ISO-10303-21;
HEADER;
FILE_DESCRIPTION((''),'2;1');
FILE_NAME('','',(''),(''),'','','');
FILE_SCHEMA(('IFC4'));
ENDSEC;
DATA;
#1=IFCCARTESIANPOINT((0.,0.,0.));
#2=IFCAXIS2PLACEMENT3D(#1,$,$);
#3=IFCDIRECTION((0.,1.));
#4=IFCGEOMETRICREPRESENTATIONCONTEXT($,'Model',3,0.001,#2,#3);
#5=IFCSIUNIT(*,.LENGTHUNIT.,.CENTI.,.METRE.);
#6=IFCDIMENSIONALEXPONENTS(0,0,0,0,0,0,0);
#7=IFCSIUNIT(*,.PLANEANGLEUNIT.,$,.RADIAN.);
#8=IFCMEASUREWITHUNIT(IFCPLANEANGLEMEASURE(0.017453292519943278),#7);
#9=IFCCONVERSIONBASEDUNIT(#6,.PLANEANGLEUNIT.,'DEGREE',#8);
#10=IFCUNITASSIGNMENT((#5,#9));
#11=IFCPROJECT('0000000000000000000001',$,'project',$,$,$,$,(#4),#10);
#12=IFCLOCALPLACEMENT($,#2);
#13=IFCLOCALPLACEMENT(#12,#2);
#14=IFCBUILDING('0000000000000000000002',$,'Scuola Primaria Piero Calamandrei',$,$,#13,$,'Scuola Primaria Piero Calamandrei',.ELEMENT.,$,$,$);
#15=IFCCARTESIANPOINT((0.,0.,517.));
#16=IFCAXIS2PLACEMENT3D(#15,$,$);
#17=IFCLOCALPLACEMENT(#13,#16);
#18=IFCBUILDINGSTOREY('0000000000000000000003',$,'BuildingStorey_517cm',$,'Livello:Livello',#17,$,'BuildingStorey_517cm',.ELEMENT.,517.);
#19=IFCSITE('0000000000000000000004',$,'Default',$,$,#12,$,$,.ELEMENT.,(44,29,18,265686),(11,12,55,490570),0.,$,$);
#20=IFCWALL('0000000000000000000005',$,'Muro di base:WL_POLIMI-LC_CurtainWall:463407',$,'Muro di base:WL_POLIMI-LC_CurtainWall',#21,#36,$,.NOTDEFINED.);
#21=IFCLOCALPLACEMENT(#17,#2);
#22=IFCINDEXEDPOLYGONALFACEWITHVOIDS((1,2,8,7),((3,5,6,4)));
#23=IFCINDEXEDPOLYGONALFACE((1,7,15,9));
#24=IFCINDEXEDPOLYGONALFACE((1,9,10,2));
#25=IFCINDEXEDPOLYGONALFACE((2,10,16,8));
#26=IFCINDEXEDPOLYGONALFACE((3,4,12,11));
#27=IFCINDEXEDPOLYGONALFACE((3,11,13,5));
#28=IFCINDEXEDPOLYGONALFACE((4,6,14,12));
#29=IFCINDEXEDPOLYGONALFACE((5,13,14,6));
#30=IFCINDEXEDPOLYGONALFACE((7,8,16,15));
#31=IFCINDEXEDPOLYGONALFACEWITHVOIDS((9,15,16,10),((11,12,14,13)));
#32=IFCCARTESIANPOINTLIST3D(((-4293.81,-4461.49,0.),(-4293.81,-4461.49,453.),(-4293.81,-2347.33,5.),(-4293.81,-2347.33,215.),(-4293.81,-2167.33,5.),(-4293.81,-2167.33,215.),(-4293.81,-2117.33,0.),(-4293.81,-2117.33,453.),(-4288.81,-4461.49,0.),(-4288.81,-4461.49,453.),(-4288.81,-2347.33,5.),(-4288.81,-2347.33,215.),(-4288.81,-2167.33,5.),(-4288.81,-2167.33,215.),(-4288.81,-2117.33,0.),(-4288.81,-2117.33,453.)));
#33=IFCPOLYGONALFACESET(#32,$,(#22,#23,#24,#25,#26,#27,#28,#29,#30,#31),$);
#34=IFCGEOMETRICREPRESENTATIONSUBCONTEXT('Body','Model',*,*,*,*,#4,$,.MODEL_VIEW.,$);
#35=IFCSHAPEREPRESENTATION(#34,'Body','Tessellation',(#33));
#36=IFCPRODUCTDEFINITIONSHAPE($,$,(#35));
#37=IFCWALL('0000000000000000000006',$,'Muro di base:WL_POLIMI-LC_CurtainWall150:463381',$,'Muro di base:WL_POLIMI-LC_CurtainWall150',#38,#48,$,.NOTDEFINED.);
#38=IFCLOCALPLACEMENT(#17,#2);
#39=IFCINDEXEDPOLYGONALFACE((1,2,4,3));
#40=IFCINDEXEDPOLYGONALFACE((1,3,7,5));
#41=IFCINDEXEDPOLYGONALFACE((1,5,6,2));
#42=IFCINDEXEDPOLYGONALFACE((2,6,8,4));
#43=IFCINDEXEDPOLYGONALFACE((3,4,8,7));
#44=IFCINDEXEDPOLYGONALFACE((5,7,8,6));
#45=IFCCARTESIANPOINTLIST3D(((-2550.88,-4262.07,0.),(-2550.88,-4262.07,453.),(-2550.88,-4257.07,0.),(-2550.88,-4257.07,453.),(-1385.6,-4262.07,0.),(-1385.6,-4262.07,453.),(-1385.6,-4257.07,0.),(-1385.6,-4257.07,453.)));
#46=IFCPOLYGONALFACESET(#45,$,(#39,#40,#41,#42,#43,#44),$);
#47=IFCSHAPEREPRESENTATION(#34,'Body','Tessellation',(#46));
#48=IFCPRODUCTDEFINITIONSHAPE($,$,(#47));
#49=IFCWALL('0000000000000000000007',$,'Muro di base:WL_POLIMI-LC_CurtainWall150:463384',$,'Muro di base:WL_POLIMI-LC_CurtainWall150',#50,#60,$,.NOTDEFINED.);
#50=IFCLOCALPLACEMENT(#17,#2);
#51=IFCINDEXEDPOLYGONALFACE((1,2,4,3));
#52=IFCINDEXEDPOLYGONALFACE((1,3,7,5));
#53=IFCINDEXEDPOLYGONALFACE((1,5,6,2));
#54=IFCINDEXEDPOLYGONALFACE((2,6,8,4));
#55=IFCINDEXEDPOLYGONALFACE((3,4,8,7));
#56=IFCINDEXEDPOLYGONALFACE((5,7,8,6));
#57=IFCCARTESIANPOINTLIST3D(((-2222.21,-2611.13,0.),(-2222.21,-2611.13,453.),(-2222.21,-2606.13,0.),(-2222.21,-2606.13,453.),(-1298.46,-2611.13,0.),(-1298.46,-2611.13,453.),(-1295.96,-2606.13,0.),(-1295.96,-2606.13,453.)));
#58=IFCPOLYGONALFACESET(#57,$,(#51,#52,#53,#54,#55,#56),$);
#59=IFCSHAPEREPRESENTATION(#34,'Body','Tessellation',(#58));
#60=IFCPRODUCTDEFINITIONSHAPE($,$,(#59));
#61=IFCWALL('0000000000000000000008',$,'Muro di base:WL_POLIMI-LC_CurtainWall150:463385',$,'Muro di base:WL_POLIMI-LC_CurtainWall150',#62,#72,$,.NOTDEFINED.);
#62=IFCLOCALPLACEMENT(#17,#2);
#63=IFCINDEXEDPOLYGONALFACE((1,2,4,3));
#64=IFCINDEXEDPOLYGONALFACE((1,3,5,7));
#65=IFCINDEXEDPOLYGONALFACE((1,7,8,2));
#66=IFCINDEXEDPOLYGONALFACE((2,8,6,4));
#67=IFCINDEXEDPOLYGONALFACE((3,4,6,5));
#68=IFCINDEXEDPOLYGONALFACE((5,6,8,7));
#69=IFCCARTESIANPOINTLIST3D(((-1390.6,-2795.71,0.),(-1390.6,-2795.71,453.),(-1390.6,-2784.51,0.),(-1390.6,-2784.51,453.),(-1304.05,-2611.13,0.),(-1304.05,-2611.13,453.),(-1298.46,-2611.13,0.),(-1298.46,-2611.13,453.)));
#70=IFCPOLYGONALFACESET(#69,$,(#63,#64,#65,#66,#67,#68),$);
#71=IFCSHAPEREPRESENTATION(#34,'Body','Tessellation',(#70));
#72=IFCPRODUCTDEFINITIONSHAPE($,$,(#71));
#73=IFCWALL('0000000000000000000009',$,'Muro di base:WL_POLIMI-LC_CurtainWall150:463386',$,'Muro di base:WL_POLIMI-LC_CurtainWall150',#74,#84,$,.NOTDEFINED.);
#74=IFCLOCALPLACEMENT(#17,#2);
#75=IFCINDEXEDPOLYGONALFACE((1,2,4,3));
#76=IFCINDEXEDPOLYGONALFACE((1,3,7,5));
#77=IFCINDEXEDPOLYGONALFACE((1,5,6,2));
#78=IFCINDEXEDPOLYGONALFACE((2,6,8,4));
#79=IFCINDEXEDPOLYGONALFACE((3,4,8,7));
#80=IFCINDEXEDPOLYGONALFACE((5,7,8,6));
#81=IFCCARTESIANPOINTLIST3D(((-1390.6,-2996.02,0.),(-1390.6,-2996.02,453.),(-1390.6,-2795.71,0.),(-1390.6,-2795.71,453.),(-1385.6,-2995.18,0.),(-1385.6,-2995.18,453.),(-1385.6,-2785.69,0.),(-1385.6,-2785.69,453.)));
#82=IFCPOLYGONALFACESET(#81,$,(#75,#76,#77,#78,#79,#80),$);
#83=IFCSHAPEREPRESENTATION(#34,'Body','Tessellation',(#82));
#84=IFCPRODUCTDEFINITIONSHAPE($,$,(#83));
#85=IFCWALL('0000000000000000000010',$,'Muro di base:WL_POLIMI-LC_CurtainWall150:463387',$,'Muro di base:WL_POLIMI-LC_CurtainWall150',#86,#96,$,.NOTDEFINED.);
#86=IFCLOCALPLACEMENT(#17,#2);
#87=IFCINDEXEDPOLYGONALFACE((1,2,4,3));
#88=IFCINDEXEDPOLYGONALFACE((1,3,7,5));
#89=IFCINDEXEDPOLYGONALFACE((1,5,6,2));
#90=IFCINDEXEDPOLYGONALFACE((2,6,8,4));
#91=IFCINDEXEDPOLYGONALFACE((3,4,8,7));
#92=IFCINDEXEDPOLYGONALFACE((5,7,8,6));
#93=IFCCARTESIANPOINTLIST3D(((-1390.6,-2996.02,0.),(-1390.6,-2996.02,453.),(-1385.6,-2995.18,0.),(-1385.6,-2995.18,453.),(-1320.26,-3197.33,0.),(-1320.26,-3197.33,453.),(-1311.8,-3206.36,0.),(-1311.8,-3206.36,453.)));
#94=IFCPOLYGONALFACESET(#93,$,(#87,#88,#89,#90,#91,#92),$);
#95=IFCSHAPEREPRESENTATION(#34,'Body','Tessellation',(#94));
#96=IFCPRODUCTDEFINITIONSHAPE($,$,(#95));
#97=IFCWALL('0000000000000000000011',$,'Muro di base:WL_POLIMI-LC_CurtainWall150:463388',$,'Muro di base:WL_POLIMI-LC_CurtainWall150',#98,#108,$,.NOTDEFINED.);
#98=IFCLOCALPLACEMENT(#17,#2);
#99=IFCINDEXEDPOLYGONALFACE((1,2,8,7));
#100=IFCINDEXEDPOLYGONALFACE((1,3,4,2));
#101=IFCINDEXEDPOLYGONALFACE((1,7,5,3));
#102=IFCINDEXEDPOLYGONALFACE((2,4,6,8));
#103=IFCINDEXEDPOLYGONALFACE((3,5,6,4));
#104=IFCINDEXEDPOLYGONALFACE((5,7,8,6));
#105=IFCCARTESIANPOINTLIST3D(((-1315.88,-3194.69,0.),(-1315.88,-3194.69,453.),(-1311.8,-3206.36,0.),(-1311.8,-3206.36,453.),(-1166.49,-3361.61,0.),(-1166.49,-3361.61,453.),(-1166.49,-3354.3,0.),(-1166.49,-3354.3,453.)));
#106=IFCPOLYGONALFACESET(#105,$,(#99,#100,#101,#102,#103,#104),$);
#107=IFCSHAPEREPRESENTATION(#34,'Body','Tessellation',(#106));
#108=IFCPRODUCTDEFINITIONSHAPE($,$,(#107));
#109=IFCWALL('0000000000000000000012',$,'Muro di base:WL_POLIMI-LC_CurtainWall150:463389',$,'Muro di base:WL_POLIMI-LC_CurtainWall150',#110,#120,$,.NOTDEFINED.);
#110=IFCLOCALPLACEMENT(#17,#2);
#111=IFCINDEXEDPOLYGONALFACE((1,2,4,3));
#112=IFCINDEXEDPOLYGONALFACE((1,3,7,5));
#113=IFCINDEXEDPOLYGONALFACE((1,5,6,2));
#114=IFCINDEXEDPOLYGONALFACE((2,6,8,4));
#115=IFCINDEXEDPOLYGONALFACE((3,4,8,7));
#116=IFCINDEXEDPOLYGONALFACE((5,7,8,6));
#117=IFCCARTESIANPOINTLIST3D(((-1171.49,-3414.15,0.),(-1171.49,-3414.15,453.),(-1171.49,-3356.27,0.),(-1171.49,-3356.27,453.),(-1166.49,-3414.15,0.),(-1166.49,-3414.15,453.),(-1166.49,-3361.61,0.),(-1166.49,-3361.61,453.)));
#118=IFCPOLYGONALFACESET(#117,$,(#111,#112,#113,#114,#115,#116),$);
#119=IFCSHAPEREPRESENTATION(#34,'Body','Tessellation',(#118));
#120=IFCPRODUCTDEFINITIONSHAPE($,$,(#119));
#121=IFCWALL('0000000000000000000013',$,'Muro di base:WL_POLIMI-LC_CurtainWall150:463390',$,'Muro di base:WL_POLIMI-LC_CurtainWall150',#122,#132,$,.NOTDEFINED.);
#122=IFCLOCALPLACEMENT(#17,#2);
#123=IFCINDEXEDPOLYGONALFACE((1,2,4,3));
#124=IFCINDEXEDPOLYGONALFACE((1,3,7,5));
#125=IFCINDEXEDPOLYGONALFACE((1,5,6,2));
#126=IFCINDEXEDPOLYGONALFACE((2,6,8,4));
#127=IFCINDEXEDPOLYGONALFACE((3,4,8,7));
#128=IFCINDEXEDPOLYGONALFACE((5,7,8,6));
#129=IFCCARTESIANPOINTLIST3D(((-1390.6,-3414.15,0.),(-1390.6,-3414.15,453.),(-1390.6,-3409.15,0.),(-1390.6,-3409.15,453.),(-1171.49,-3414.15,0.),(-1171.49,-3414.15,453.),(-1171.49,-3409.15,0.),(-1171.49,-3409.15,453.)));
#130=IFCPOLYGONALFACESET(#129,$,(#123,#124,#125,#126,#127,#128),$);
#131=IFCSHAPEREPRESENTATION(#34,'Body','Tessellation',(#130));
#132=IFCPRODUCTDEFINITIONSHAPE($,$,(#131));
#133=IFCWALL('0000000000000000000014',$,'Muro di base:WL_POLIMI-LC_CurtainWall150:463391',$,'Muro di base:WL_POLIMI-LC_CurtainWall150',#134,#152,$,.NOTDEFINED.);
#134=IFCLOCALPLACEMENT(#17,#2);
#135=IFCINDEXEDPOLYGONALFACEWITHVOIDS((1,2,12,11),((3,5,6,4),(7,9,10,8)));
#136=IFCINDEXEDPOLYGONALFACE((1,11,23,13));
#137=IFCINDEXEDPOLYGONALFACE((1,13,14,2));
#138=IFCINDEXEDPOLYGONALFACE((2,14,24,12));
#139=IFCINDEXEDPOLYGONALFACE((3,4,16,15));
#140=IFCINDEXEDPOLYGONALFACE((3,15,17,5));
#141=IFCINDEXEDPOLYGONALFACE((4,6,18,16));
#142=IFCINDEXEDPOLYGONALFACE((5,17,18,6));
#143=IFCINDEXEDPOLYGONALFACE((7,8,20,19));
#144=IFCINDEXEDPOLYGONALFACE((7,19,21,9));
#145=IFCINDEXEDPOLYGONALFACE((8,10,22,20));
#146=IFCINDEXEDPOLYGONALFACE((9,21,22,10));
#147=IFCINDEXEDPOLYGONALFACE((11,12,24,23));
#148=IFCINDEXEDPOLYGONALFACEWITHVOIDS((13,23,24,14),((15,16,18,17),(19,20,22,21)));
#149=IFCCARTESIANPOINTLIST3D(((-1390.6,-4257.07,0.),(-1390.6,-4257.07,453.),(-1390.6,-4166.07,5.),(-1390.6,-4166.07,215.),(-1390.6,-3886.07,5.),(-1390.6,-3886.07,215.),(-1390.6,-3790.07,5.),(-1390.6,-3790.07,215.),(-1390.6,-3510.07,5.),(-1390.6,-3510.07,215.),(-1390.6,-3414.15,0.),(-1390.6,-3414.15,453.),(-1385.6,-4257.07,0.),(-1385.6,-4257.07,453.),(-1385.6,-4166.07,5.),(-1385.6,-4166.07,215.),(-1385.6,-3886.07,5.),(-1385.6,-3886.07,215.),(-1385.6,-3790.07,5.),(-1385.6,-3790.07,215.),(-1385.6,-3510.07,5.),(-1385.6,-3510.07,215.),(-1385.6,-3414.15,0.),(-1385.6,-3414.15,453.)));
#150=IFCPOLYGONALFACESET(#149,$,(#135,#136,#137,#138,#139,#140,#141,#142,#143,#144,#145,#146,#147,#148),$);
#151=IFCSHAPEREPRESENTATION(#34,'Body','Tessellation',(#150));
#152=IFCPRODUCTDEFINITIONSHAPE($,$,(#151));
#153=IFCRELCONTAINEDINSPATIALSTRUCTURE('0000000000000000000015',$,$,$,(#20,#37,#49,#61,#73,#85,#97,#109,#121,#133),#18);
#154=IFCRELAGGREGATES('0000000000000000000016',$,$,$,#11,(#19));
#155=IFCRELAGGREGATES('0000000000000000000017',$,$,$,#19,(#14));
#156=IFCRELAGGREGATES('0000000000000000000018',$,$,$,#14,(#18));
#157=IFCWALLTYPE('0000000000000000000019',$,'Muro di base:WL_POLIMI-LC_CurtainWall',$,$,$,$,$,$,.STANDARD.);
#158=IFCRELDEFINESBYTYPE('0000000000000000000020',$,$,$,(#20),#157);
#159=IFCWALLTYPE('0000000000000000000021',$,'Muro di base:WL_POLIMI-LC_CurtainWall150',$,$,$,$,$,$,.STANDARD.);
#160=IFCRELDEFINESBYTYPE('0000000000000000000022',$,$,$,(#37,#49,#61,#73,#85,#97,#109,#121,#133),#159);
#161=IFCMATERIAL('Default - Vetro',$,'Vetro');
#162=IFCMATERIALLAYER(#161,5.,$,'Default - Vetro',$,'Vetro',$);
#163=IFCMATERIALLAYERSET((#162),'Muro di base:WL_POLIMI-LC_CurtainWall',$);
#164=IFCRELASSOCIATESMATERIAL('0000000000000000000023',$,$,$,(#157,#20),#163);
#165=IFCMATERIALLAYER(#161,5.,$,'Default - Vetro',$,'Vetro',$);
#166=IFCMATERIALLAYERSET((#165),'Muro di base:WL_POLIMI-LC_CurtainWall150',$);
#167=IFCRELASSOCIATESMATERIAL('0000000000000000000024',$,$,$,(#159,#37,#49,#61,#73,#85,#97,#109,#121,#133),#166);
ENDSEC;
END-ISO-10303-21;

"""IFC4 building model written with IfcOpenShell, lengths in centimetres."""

from ifc_helpers import new_model, entity, si_unit, converted_unit, direction, frame, frame_2d, origin, place, context, subcontext, project, spatial, polyline, rectangle, outline, extrude, clip, bounded_halfspace, material, layer, layer_set, layer_usage, type_object, element, save


model = new_model("IFC4")

# Units and contexts
model_context = context("Model", 3, precision=0.001, world=origin(), true_north=direction((0.0, 1.0)))
body_context = subcontext(model_context, "Body", "Model", "MODEL_VIEW")
ifc_project = project(units=[si_unit("LENGTHUNIT", "METRE", prefix="CENTI"), converted_unit("PLANEANGLEUNIT", "DEGREE", entity("IfcPlaneAngleMeasure", 0.017453292519943278), si_unit("PLANEANGLEUNIT", "RADIAN"), dimensions=[0, 0, 0, 0, 0, 0, 0])], contexts=[model_context])

# Site, building, storey
site_placement = place(None, origin())
site = spatial("IfcSite", under=ifc_project, at=site_placement, Name="Default", CompositionType="ELEMENT", RefLatitude=(44, 29, 18, 265686), RefLongitude=(11, 12, 55, 490570), RefElevation=0.0)
building_placement = place(site_placement, origin())
building = spatial("IfcBuilding", under=site, at=building_placement, Name="Scuola Primaria Piero Calamandrei", LongName="Scuola Primaria Piero Calamandrei", CompositionType="ELEMENT")
storey_placement = place(building_placement, frame((0.0, 0.0, 517.0)))
storey = spatial("IfcBuildingStorey", under=building, at=storey_placement, Name="BuildingStorey_517cm", ObjectType="Livello:Livello", LongName="BuildingStorey_517cm", CompositionType="ELEMENT", Elevation=517.0)

# Wall, opening
ifc_material_1 = material(Name="Default - Vetro", Category="Vetro")
ifc_layer_1 = layer(ifc_material_1, 5.0, Name="Default - Vetro", Category="Vetro")
ifc_layer_set_1 = layer_set([ifc_layer_1], Name="Muro di base:WL_POLIMI-LC_CurtainWall")
ifc_layer_usage_1 = layer_usage(ifc_layer_set_1, "AXIS2", "NEGATIVE", 2.5)
wall_type_1 = type_object("IfcWallType", Name="Muro di base:WL_POLIMI-LC_CurtainWall", PredefinedType="STANDARD", material=ifc_layer_set_1)
wall_1_placement = place(storey_placement, frame((-4291.31, -4461.49, 0.0), z_axis=(0.0, 0.0, 1.0), x_axis=(0.0, 1.0, 0.0)))
wall_1 = element("IfcWall", 1, at=wall_1_placement, inside=storey, type_object=wall_type_1, material=ifc_layer_usage_1, Name="Muro di base:WL_POLIMI-LC_CurtainWall:463407", ObjectType="Muro di base:WL_POLIMI-LC_CurtainWall", PredefinedType="NOTDEFINED", context=body_context, shape_type="Clipping", body=[
    clip(extrude(rectangle(XDim=2344.16, YDim=5.0, at=frame_2d((1172.08, 0.0), x_axis=(-1.0, 0.0))), origin(), (0.0, 0.0, 1.0), 453.0), bounded_halfspace(frame((0.0, -2.5, 453.0), z_axis=(0.0, 0.0, 1.0), x_axis=(0.0, -1.0, 0.0)), False, frame((0.0, -2.5, 453.0)), polyline([(0.0, 0.0), (2332.66, 0.0), (2344.16, 0.0), (2344.16, 5.0), (0.0, 5.0), (0.0, 0.0)]))),
])
opening_1_placement = place(wall_1_placement, frame((2114.16, -2.5, 5.0)))
element("IfcOpeningElement", 2, at=opening_1_placement, cuts=wall_1, PredefinedType="OPENING", context=body_context, shape_type="SweptSolid", body=[
    extrude(rectangle(XDim=210.0, YDim=180.0, at=frame_2d((105.0, 90.0), x_axis=(-1.0, 0.0))), frame((0.0, 0.0, 0.0), z_axis=(0.0, 1.0, 0.0), x_axis=(0.0, 0.0, 1.0)), (0.0, 0.0, 1.0), 5.0),
])

# Walls
ifc_layer_2 = layer(ifc_material_1, 5.0, Name="Default - Vetro", Category="Vetro")
ifc_layer_set_2 = layer_set([ifc_layer_2], Name="Muro di base:WL_POLIMI-LC_CurtainWall150")
ifc_layer_usage_2 = layer_usage(ifc_layer_set_2, "AXIS2", "NEGATIVE", 2.5)
wall_type_2 = type_object("IfcWallType", Name="Muro di base:WL_POLIMI-LC_CurtainWall150", PredefinedType="STANDARD", material=ifc_layer_set_2)
wall_2_placement = place(storey_placement, frame((-1385.6, -4259.57, 0.0), z_axis=(0.0, 0.0, 1.0), x_axis=(-1.0, 0.0, 0.0)))
element("IfcWall", 3, at=wall_2_placement, inside=storey, type_object=wall_type_2, material=ifc_layer_usage_2, Name="Muro di base:WL_POLIMI-LC_CurtainWall150:463381", ObjectType="Muro di base:WL_POLIMI-LC_CurtainWall150", PredefinedType="NOTDEFINED", context=body_context, shape_type="Clipping", body=[
    clip(extrude(rectangle(XDim=1165.28, YDim=5.0, at=frame_2d((582.64, 0.0), x_axis=(-1.0, 0.0))), origin(), (0.0, 0.0, 1.0), 453.0), bounded_halfspace(frame((0.0, -2.5, 453.0), z_axis=(0.0, 0.0, 1.0), x_axis=(-1.0, 0.0, 0.0)), False, frame((0.0, -2.5, 453.0)), polyline([(0.0, 0.0), (5.0, 0.0), (1165.28, 0.0), (1165.28, 5.0), (0.0, 5.0), (0.0, 0.0)]))),
])
ifc_layer_usage_3 = layer_usage(ifc_layer_set_2, "AXIS2", "NEGATIVE", 2.5)
wall_3_placement = place(storey_placement, frame((-2222.21, -2608.63, 0.0)))
element("IfcWall", 4, at=wall_3_placement, inside=storey, type_object=wall_type_2, material=ifc_layer_usage_3, Name="Muro di base:WL_POLIMI-LC_CurtainWall150:463384", ObjectType="Muro di base:WL_POLIMI-LC_CurtainWall150", PredefinedType="NOTDEFINED", context=body_context, shape_type="Clipping", body=[
    clip(extrude(outline(polyline([(923.75, -2.5), (926.24, 2.5), (0.0, 2.5), (0.0, -2.5), (918.16, -2.5), (923.75, -2.5)])), origin(), (0.0, 0.0, 1.0), 453.0), bounded_halfspace(frame((0.0, -2.5, 453.0)), False, frame((0.0, -2.5, 453.0)), polyline([(0.0, 0.0), (918.16, 0.0), (923.75, 0.0), (926.24, 5.0), (0.0, 5.0), (0.0, 0.0)]))),
])
ifc_layer_usage_4 = layer_usage(ifc_layer_set_2, "AXIS2", "NEGATIVE", 2.5)
wall_4_placement = place(storey_placement, frame((-1300.7, -2610.01, 0.0), z_axis=(0.0, 0.0, 1.0), x_axis=(-0.446642, -0.894713, 0.0)))
element("IfcWall", 5, at=wall_4_placement, inside=storey, type_object=wall_type_2, material=ifc_layer_usage_4, Name="Muro di base:WL_POLIMI-LC_CurtainWall150:463385", ObjectType="Muro di base:WL_POLIMI-LC_CurtainWall150", PredefinedType="NOTDEFINED", context=body_context, shape_type="Clipping", body=[
    clip(extrude(outline(polyline([(196.28, -2.5), (206.3, 2.5), (195.1, 2.5), (0.0, 2.5), (2.5, -2.5), (196.28, -2.5)])), origin(), (0.0, 0.0, 1.0), 453.0), bounded_halfspace(frame((2.5, -2.5, 453.0), z_axis=(0.0, 0.0, 1.0), x_axis=(-0.446642, 0.894713, 0.0)), False, frame((2.5, -2.5, 453.0)), polyline([(0.0, 0.0), (193.78, 0.0), (203.8, 5.0), (192.61, 5.0), (-2.5, 5.0), (0.0, 0.0)]))),
])
ifc_layer_usage_5 = layer_usage(ifc_layer_set_2, "AXIS2", "NEGATIVE", 2.5)
wall_5_placement = place(storey_placement, frame((-1388.1, -2785.69, 0.0), z_axis=(0.0, 0.0, 1.0), x_axis=(0.0, -1.0, 0.0)))
element("IfcWall", 6, at=wall_5_placement, inside=storey, type_object=wall_type_2, material=ifc_layer_usage_5, Name="Muro di base:WL_POLIMI-LC_CurtainWall150:463386", ObjectType="Muro di base:WL_POLIMI-LC_CurtainWall150", PredefinedType="NOTDEFINED", context=body_context, shape_type="Clipping", body=[
    clip(extrude(outline(polyline([(210.34, -2.5), (209.49, 2.5), (0.0, 2.5), (10.02, -2.5), (210.34, -2.5)])), origin(), (0.0, 0.0, 1.0), 453.0), bounded_halfspace(frame((10.02, -2.5, 453.0), z_axis=(0.0, 0.0, 1.0), x_axis=(0.0, 1.0, 0.0)), False, frame((10.02, -2.5, 453.0)), polyline([(0.0, 0.0), (200.32, 0.0), (199.47, 5.0), (-10.02, 5.0), (0.0, 0.0)]))),
])
ifc_layer_usage_6 = layer_usage(ifc_layer_set_2, "AXIS2", "NEGATIVE", 2.5)
wall_6_placement = place(storey_placement, frame((-1388.24, -2995.2, 0.0), z_axis=(0.0, 0.0, 1.0), x_axis=(0.32988, -0.944023, 0.0)))
element("IfcWall", 7, at=wall_6_placement, inside=storey, type_object=wall_type_2, material=ifc_layer_usage_6, Name="Muro di base:WL_POLIMI-LC_CurtainWall150:463387", ObjectType="Muro di base:WL_POLIMI-LC_CurtainWall150", PredefinedType="NOTDEFINED", context=body_context, shape_type="Clipping", body=[
    clip(extrude(outline(polyline([(213.25, -2.5), (224.56, 2.5), (212.19, 2.5), (0.85, 2.5), (0.0, -2.5), (213.25, -2.5)])), origin(), (0.0, 0.0, 1.0), 453.0), bounded_halfspace(frame((0.0, -2.5, 453.0), z_axis=(0.0, 0.0, 1.0), x_axis=(0.32988, 0.944023, 0.0)), False, frame((0.0, -2.5, 453.0)), polyline([(0.0, 0.0), (213.25, 0.0), (224.56, 5.0), (212.19, 5.0), (0.85, 5.0), (0.0, 0.0)]))),
])
ifc_layer_usage_7 = layer_usage(ifc_layer_set_2, "AXIS2", "NEGATIVE", 2.5)
wall_7_placement = place(storey_placement, frame((-1317.71, -3196.4, 0.0), z_axis=(0.0, 0.0, 1.0), x_axis=(0.683359, -0.730082, 0.0)))
element("IfcWall", 8, at=wall_7_placement, inside=storey, type_object=wall_type_2, material=ifc_layer_usage_7, Name="Muro di base:WL_POLIMI-LC_CurtainWall150:463388", ObjectType="Muro di base:WL_POLIMI-LC_CurtainWall150", PredefinedType="NOTDEFINED", context=body_context, shape_type="Clipping", body=[
    clip(extrude(outline(polyline([(223.96, -2.5), (218.62, 2.5), (0.0, 2.5), (11.31, -2.5), (216.64, -2.5), (223.96, -2.5)])), origin(), (0.0, 0.0, 1.0), 453.0), bounded_halfspace(frame((11.31, -2.5, 453.0), z_axis=(0.0, 0.0, 1.0), x_axis=(0.683359, 0.730082, 0.0)), False, frame((11.31, -2.5, 453.0)), polyline([(0.0, 0.0), (205.33, 0.0), (212.65, 0.0), (207.31, 5.0), (-11.31, 5.0), (0.0, 0.0)]))),
])
ifc_layer_usage_8 = layer_usage(ifc_layer_set_2, "AXIS2", "NEGATIVE", 2.5)
wall_8_placement = place(storey_placement, frame((-1168.99, -3356.27, 0.0), z_axis=(0.0, 0.0, 1.0), x_axis=(0.0, -1.0, 0.0)))
element("IfcWall", 9, at=wall_8_placement, inside=storey, type_object=wall_type_2, material=ifc_layer_usage_8, Name="Muro di base:WL_POLIMI-LC_CurtainWall150:463389", ObjectType="Muro di base:WL_POLIMI-LC_CurtainWall150", PredefinedType="NOTDEFINED", context=body_context, shape_type="Clipping", body=[
    clip(extrude(outline(polyline([(57.88, -2.5), (57.88, 2.5), (5.34, 2.5), (0.0, -2.5), (52.88, -2.5), (57.88, -2.5)])), origin(), (0.0, 0.0, 1.0), 453.0), bounded_halfspace(frame((0.0, -2.5, 453.0), z_axis=(0.0, 0.0, 1.0), x_axis=(0.0, 1.0, 0.0)), False, frame((0.0, -2.5, 453.0)), polyline([(0.0, 0.0), (52.88, 0.0), (57.88, 0.0), (57.88, 5.0), (5.34, 5.0), (0.0, 0.0)]))),
])
ifc_layer_usage_9 = layer_usage(ifc_layer_set_2, "AXIS2", "NEGATIVE", 2.5)
wall_9_placement = place(storey_placement, frame((-1171.49, -3411.65, 0.0), z_axis=(0.0, 0.0, 1.0), x_axis=(-1.0, 0.0, 0.0)))
element("IfcWall", 10, at=wall_9_placement, inside=storey, type_object=wall_type_2, material=ifc_layer_usage_9, Name="Muro di base:WL_POLIMI-LC_CurtainWall150:463390", ObjectType="Muro di base:WL_POLIMI-LC_CurtainWall150", PredefinedType="NOTDEFINED", context=body_context, shape_type="Clipping", body=[
    clip(extrude(rectangle(XDim=219.11, YDim=5.0, at=frame_2d((109.56, 0.0), x_axis=(-1.0, 0.0))), origin(), (0.0, 0.0, 1.0), 453.0), bounded_halfspace(frame((0.0, -2.5, 453.0), z_axis=(0.0, 0.0, 1.0), x_axis=(-1.0, 0.0, 0.0)), False, frame((0.0, -2.5, 453.0)), polyline([(0.0, 0.0), (219.11, 0.0), (219.11, 5.0), (214.11, 5.0), (0.0, 5.0), (0.0, 0.0)]))),
])

# Wall, openings
ifc_layer_usage_10 = layer_usage(ifc_layer_set_2, "AXIS2", "NEGATIVE", 2.5)
wall_10_placement = place(storey_placement, frame((-1388.1, -3414.15, 0.0), z_axis=(0.0, 0.0, 1.0), x_axis=(0.0, -1.0, 0.0)))
wall_10 = element("IfcWall", 11, at=wall_10_placement, inside=storey, type_object=wall_type_2, material=ifc_layer_usage_10, Name="Muro di base:WL_POLIMI-LC_CurtainWall150:463391", ObjectType="Muro di base:WL_POLIMI-LC_CurtainWall150", PredefinedType="NOTDEFINED", context=body_context, shape_type="Clipping", body=[
    clip(extrude(rectangle(XDim=842.92, YDim=5.0, at=frame_2d((421.46, 0.0), x_axis=(-1.0, 0.0))), origin(), (0.0, 0.0, 1.0), 453.0), bounded_halfspace(frame((0.0, -2.5, 453.0), z_axis=(0.0, 0.0, 1.0), x_axis=(0.0, 1.0, 0.0)), False, frame((0.0, -2.5, 453.0)), polyline([(0.0, 0.0), (842.92, 0.0), (842.92, 5.0), (0.0, 5.0), (0.0, 0.0)]))),
])
opening_2_placement = place(wall_10_placement, frame((471.92, -2.5, 5.0)))
element("IfcOpeningElement", 12, at=opening_2_placement, cuts=wall_10, PredefinedType="OPENING", context=body_context, shape_type="SweptSolid", body=[
    extrude(rectangle(XDim=210.0, YDim=280.0, at=frame_2d((105.0, 140.0), x_axis=(-1.0, 0.0))), frame((0.0, 0.0, 0.0), z_axis=(0.0, 1.0, 0.0), x_axis=(0.0, 0.0, 1.0)), (0.0, 0.0, 1.0), 5.0),
])
opening_3_placement = place(wall_10_placement, frame((95.92, -2.5, 5.0)))
element("IfcOpeningElement", 13, at=opening_3_placement, cuts=wall_10, PredefinedType="OPENING", context=body_context, shape_type="SweptSolid", body=[
    extrude(rectangle(XDim=210.0, YDim=280.0, at=frame_2d((105.0, 140.0), x_axis=(-1.0, 0.0))), frame((0.0, 0.0, 0.0), z_axis=(0.0, 1.0, 0.0), x_axis=(0.0, 0.0, 1.0)), (0.0, 0.0, 1.0), 5.0),
])

save(model, "model.ifc")
